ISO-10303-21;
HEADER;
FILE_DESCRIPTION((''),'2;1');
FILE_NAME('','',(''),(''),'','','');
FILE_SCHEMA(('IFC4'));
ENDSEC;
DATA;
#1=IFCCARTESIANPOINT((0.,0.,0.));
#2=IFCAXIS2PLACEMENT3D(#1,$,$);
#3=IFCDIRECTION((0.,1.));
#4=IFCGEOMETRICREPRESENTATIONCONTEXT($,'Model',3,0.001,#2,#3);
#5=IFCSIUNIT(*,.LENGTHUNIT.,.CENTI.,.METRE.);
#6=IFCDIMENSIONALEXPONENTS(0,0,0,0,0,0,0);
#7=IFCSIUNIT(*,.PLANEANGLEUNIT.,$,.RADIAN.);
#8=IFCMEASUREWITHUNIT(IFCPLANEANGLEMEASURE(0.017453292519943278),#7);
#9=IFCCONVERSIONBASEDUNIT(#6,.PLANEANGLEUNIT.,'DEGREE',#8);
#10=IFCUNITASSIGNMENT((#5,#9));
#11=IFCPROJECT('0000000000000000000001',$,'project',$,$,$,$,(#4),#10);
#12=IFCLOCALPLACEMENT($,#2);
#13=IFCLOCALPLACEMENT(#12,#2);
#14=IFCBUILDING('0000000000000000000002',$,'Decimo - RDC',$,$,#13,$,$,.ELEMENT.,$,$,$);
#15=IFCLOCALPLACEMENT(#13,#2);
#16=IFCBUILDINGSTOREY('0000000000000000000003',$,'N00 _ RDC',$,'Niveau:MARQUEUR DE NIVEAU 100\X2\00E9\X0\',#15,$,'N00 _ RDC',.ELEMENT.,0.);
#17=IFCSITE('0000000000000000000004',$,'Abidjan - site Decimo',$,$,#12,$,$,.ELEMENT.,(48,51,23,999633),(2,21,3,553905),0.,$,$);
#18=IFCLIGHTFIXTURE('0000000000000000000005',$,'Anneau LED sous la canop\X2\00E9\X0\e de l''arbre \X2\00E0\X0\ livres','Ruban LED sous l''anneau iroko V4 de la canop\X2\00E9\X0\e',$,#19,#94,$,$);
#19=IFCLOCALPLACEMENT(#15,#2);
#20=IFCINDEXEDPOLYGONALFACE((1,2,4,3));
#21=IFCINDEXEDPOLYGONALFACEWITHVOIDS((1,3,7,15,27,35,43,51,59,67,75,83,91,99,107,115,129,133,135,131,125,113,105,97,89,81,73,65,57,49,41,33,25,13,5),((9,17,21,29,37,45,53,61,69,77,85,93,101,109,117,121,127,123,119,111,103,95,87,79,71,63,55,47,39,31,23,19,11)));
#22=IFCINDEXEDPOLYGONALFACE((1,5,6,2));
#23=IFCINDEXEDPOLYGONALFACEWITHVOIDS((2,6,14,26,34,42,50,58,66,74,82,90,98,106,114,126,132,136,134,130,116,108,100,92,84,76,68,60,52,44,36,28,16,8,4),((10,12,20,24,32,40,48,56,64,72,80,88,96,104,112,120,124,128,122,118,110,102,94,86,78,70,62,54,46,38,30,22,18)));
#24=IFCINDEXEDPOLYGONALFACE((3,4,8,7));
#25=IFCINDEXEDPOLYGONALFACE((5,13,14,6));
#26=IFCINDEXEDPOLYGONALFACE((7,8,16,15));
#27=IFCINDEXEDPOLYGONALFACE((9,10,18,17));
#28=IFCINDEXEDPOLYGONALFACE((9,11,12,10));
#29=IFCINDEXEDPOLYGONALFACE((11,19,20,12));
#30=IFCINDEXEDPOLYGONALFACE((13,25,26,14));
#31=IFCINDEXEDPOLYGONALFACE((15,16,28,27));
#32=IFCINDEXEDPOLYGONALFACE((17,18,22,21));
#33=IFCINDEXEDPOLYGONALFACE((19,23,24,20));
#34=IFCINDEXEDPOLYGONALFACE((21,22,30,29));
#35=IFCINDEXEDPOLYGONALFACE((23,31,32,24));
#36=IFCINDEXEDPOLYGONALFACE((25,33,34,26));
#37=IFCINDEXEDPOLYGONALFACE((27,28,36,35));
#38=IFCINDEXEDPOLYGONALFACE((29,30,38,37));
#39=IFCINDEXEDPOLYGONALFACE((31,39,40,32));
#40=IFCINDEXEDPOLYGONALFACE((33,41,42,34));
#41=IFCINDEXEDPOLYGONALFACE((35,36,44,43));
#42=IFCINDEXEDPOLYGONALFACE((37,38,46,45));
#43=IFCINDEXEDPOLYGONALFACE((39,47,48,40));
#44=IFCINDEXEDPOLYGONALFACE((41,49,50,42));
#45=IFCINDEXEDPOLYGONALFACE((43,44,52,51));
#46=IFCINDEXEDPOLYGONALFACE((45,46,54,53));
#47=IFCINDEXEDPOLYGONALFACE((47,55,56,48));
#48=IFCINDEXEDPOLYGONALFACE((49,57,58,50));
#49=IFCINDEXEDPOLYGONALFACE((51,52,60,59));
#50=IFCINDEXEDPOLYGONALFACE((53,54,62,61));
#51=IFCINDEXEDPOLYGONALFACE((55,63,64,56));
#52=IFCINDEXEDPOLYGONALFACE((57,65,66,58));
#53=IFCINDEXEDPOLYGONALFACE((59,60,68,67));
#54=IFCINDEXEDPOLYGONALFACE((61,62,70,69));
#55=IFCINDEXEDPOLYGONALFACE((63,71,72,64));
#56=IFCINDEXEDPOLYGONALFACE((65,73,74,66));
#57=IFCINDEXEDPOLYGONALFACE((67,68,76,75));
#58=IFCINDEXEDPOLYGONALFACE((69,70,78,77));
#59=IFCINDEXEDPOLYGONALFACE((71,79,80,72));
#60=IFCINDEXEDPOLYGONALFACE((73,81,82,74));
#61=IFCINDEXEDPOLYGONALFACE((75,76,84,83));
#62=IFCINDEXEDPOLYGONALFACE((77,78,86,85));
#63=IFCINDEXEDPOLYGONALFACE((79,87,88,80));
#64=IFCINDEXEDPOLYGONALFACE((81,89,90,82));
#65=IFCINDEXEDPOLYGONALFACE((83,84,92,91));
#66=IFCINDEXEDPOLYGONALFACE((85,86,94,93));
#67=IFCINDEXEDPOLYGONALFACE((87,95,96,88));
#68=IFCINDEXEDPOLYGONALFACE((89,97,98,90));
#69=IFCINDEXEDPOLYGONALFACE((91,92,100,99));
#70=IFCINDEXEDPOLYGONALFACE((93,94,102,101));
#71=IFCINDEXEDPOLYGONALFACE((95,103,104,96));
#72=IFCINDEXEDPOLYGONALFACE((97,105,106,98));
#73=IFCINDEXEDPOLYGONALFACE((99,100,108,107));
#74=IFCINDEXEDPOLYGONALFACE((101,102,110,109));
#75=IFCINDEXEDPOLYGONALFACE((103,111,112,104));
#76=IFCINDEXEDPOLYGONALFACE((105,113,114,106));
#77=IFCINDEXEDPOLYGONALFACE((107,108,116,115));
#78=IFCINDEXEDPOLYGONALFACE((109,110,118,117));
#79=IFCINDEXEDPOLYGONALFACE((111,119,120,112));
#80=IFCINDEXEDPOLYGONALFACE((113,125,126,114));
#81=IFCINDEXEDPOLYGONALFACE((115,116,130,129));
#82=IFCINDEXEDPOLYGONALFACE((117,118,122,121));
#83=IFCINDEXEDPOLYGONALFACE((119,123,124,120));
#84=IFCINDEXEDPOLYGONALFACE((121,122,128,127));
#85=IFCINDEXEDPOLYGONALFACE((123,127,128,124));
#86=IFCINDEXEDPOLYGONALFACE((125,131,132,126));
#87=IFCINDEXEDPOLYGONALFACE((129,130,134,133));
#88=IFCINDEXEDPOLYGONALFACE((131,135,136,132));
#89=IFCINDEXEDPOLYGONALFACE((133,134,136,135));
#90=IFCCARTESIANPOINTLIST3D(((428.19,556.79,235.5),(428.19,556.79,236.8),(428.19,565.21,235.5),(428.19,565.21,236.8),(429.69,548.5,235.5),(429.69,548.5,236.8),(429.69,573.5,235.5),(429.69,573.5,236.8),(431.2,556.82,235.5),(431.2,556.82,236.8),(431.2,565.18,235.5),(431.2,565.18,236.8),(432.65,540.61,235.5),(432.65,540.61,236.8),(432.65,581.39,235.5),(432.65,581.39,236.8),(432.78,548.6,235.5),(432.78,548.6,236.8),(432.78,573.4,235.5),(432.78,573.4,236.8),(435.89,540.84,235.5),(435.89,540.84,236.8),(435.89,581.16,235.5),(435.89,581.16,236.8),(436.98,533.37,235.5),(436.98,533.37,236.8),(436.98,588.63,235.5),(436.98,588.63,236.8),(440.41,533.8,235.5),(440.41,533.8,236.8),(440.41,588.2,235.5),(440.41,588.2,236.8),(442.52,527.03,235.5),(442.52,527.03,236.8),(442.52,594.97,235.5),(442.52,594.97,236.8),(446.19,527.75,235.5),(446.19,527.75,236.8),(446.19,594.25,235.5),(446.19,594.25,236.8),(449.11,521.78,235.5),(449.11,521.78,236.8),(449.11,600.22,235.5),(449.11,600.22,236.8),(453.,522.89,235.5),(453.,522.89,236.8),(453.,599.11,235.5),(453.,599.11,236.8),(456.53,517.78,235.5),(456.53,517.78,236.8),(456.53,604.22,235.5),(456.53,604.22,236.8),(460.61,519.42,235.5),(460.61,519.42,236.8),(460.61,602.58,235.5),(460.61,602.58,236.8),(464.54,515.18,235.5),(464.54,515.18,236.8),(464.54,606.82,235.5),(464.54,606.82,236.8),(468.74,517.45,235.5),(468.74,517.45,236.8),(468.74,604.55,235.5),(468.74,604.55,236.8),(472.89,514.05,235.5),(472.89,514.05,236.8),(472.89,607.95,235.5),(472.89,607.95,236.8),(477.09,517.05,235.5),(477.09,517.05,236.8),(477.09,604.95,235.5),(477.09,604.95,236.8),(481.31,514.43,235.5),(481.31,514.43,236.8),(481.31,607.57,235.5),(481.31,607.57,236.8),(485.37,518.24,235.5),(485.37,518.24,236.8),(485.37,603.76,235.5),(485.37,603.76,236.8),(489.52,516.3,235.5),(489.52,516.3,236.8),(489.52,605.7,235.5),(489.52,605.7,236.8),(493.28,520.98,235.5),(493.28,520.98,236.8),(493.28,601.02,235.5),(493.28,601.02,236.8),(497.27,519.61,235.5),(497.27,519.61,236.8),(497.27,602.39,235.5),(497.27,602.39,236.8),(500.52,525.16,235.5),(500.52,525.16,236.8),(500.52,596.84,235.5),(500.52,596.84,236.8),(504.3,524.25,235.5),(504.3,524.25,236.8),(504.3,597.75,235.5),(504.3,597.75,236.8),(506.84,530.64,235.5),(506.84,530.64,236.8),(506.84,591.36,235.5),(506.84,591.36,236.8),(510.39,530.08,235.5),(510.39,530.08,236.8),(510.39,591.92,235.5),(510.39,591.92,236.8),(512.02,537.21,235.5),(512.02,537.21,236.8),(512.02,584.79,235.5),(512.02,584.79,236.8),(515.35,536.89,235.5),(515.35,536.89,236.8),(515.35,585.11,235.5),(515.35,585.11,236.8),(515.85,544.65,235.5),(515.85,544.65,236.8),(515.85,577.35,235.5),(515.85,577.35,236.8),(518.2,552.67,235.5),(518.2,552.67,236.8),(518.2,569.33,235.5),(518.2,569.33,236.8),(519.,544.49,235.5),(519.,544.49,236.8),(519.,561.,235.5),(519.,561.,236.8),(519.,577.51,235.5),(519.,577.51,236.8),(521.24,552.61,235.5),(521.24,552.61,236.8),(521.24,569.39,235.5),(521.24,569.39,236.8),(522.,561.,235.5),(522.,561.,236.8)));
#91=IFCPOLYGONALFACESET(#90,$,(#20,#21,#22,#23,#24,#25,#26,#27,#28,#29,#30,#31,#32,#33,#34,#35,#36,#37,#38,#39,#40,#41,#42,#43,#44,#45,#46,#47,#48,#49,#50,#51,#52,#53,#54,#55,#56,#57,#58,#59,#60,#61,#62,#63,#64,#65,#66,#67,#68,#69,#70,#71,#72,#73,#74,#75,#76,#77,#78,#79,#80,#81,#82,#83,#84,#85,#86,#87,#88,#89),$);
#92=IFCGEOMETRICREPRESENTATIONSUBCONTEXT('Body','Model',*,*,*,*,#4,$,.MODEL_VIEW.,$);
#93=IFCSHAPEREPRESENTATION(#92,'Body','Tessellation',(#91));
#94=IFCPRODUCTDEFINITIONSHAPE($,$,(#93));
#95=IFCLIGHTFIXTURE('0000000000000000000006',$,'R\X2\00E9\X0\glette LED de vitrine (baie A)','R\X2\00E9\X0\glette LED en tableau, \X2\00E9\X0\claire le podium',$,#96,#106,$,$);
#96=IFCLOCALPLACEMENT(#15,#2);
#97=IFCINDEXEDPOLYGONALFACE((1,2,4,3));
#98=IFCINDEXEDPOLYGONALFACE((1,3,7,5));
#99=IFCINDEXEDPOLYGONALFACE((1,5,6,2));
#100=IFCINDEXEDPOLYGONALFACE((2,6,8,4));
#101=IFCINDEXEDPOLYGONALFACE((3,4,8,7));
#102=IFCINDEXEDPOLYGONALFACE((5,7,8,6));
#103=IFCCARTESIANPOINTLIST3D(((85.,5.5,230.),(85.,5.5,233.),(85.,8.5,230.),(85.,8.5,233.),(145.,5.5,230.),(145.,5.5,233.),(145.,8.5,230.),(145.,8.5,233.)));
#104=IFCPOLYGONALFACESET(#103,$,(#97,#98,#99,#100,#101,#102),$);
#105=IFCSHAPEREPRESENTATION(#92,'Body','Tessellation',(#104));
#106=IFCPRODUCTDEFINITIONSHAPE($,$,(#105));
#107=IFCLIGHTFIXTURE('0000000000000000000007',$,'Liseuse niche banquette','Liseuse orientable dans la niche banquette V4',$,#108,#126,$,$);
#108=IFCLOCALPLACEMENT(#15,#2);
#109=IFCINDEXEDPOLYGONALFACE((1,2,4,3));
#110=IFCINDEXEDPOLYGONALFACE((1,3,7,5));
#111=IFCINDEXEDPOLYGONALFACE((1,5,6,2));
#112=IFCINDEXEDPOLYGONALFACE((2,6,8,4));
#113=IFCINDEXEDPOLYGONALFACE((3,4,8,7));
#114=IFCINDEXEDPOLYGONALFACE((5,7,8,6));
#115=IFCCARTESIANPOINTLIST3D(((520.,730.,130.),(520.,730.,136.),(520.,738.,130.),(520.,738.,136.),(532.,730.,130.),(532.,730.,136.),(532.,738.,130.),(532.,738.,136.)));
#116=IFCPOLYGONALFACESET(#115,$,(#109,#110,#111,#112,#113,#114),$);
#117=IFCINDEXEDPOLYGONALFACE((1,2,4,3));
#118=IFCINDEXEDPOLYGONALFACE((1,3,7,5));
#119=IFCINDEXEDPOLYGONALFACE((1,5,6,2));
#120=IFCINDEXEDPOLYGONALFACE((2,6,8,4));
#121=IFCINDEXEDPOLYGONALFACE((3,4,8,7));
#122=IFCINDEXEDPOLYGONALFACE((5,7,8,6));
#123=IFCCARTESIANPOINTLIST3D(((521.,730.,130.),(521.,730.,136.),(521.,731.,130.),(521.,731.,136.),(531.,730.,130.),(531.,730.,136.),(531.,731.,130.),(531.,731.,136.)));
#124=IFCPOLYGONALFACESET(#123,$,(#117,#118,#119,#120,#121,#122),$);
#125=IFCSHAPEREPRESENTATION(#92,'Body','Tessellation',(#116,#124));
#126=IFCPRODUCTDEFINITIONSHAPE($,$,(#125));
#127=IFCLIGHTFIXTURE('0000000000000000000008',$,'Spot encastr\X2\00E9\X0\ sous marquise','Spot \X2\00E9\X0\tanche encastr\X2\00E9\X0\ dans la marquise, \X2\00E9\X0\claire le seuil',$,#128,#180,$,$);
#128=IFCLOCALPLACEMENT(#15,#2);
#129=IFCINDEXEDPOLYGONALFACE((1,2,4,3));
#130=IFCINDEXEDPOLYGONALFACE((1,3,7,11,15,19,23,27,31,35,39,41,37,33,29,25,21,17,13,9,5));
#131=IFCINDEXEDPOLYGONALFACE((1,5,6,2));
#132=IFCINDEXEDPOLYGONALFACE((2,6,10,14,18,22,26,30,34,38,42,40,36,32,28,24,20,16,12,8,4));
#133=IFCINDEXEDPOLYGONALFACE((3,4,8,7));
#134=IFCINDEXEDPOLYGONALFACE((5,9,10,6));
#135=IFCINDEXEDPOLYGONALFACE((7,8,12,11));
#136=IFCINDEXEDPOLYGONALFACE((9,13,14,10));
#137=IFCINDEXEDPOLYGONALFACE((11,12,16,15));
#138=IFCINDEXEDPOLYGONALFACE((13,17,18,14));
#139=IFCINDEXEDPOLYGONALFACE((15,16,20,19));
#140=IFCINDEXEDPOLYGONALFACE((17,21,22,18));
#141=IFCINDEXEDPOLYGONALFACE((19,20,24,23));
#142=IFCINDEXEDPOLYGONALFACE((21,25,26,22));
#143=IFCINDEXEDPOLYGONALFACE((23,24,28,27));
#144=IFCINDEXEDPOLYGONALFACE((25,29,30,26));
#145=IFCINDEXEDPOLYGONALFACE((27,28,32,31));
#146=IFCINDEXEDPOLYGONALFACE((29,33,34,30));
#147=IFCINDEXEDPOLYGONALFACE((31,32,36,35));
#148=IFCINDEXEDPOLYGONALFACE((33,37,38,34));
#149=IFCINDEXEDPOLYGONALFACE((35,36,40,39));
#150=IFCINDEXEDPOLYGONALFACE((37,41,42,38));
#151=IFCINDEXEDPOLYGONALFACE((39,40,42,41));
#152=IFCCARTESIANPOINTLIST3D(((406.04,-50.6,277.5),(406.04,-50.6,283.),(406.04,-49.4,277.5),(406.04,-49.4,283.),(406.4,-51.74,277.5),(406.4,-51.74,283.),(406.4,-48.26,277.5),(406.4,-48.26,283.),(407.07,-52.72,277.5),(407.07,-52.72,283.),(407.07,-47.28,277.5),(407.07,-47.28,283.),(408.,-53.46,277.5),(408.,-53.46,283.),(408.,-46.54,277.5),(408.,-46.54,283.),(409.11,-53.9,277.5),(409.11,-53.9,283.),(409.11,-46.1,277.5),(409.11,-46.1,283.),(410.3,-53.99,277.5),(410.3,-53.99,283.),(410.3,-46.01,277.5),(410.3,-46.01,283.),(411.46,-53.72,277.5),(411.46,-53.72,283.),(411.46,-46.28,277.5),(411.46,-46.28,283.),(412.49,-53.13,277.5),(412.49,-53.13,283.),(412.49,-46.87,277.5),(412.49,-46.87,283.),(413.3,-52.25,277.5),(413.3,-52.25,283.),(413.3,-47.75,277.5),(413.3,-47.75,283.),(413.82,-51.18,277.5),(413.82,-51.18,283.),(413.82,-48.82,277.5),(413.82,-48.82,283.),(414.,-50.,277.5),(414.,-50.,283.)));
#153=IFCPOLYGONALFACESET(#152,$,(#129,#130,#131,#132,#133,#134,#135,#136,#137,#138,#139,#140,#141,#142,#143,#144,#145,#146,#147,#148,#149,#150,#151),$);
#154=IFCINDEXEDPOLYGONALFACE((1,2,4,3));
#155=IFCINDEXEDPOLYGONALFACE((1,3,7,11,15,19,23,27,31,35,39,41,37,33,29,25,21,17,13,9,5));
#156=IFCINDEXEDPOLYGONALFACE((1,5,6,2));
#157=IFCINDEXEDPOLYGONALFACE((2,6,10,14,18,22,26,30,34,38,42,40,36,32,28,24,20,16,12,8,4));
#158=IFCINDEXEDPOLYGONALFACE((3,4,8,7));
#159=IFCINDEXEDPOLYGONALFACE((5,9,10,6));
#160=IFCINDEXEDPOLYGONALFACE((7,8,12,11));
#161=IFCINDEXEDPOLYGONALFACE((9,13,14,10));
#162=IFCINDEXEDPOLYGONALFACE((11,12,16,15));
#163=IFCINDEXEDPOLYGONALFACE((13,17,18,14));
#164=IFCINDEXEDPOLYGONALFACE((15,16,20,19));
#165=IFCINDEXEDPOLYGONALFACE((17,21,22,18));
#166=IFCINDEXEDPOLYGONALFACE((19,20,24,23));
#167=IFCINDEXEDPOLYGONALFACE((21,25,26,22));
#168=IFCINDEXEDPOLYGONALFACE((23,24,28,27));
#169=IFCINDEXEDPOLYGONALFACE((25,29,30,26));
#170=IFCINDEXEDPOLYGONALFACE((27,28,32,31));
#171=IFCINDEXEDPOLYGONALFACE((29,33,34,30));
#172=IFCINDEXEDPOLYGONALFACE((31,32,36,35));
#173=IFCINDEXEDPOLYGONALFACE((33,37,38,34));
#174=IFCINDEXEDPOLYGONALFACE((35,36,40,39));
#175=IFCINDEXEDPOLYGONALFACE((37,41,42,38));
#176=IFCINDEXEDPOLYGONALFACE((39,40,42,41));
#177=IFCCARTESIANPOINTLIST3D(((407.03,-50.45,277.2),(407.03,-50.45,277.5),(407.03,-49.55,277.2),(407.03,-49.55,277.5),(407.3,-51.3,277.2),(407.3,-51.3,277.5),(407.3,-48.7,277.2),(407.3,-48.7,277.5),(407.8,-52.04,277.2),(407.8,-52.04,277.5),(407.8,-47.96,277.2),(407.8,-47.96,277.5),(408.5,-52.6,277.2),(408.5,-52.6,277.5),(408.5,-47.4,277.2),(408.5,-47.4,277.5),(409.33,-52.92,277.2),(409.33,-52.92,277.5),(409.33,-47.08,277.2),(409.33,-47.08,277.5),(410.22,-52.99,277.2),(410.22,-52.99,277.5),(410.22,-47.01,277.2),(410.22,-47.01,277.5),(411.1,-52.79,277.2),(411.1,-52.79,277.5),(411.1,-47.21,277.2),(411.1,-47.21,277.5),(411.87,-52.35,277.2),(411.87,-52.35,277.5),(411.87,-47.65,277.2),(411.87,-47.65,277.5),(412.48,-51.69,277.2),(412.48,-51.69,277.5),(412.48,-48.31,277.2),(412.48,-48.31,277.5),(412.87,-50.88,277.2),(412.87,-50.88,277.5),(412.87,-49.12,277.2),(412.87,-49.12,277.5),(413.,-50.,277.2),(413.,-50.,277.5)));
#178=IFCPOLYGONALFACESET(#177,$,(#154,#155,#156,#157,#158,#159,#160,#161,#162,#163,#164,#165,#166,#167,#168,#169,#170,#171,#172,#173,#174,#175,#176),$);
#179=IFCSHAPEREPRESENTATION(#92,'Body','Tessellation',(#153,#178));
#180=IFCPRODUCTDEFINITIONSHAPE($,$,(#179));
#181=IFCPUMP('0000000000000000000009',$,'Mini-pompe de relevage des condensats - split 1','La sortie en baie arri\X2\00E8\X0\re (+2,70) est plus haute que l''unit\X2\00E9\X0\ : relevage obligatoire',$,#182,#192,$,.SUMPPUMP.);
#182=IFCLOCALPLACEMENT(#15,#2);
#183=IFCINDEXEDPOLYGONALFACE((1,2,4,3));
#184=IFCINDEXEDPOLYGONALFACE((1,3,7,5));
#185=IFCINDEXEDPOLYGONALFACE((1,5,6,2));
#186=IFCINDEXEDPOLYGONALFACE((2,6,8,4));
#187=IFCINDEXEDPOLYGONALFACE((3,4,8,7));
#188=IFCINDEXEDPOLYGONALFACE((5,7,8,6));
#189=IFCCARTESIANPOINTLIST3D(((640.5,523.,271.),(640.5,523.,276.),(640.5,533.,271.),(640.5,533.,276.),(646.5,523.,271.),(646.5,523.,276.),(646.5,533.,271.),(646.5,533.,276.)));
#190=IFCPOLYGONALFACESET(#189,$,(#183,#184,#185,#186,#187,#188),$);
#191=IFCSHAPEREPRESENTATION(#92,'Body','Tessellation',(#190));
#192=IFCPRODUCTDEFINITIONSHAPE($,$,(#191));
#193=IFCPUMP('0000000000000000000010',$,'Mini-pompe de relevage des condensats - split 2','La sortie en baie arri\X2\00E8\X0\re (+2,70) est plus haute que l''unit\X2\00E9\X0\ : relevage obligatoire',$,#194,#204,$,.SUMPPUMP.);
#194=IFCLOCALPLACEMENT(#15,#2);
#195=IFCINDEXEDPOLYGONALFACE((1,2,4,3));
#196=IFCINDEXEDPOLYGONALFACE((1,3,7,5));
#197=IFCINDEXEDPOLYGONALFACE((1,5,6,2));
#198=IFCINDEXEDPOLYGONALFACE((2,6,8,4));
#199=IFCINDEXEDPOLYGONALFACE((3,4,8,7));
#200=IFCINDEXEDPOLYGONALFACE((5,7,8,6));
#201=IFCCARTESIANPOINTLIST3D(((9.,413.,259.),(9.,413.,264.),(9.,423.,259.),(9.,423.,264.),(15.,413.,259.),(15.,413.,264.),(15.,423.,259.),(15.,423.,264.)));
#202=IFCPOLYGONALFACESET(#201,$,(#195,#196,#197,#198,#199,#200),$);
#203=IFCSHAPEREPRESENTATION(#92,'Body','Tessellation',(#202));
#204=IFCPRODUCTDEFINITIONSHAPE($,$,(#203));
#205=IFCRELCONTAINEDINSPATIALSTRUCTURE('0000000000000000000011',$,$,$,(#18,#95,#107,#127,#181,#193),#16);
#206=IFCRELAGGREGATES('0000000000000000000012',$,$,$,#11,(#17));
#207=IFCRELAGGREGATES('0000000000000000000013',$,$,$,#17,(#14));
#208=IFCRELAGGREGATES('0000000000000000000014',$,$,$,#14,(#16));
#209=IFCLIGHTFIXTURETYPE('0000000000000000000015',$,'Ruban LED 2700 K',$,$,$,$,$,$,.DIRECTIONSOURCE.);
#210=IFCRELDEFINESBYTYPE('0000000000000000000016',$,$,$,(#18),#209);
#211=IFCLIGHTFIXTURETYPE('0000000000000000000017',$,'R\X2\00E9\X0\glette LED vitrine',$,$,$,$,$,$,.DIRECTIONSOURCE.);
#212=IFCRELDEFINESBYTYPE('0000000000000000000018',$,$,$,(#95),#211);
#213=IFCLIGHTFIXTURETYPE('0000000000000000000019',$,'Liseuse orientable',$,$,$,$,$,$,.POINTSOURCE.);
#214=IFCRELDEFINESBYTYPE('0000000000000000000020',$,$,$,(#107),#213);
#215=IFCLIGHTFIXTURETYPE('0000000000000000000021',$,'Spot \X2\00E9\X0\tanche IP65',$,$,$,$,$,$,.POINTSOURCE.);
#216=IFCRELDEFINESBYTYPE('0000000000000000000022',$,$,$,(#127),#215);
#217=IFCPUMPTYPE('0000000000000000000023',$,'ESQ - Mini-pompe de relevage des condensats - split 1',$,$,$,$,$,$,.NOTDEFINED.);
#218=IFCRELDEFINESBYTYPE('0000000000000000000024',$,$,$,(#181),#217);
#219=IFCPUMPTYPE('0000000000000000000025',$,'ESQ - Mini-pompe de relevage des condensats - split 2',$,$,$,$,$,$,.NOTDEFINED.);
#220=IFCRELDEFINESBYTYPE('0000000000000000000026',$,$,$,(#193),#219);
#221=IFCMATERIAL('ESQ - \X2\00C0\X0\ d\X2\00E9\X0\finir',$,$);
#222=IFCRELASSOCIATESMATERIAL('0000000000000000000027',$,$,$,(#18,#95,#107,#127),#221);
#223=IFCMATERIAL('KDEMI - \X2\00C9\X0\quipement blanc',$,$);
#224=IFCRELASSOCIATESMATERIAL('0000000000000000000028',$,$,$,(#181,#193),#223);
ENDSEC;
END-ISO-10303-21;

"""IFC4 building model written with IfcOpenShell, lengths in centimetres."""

from ifc_helpers import new_model, entity, si_unit, converted_unit, direction, frame, frame_2d, origin, origin_with_axes, place, context, subcontext, project, spatial, rectangle, circle, hollow_circle, extrude, material, type_object, element, save


model = new_model("IFC4")

# Units and contexts
model_context = context("Model", 3, precision=0.001, world=origin(), true_north=direction((0.0, 1.0)))
body_context = subcontext(model_context, "Body", "Model", "MODEL_VIEW")
ifc_project = project(units=[si_unit("LENGTHUNIT", "METRE", prefix="CENTI"), converted_unit("PLANEANGLEUNIT", "DEGREE", entity("IfcPlaneAngleMeasure", 0.017453292519943278), si_unit("PLANEANGLEUNIT", "RADIAN"), dimensions=[0, 0, 0, 0, 0, 0, 0])], contexts=[model_context])

# Site, building, storey
site_placement = place(None, origin())
site = spatial("IfcSite", under=ifc_project, at=site_placement, Name="Abidjan - site Decimo", CompositionType="ELEMENT", RefLatitude=(48, 51, 23, 999633), RefLongitude=(2, 21, 3, 553905), RefElevation=0.0)
building_placement = place(site_placement, origin())
building = spatial("IfcBuilding", under=site, at=building_placement, Name="Decimo - RDC", CompositionType="ELEMENT")
storey_placement = place(building_placement, origin())
storey = spatial("IfcBuildingStorey", under=building, at=storey_placement, Name="N00 _ RDC", ObjectType="Niveau:MARQUEUR DE NIVEAU 100é", LongName="N00 _ RDC", CompositionType="ELEMENT", Elevation=0.0)

# Light fixtures
ifc_material_1 = material(Name="ESQ - À définir")
light_fixture_type_1 = type_object("IfcLightFixtureType", Name="Ruban LED 2700 K", PredefinedType="DIRECTIONSOURCE")
light_fixture_1_placement = place(storey_placement, origin_with_axes())
element("IfcLightFixture", 1, at=light_fixture_1_placement, inside=storey, type_object=light_fixture_type_1, material=ifc_material_1, Name="Anneau LED sous la canopée de l'arbre à livres", Description="Ruban LED sous l'anneau iroko V4 de la canopée", context=body_context, shape_type="SweptSolid", body=[
    extrude(hollow_circle(Radius=47.0, WallThickness=3.0, at=frame_2d((475.0, 561.0))), frame((0.0, 0.0, 235.5)), (0.0, 0.0, 1.0), 1.3),
])
light_fixture_type_2 = type_object("IfcLightFixtureType", Name="Réglette LED vitrine", PredefinedType="DIRECTIONSOURCE")
light_fixture_2_placement = place(storey_placement, origin_with_axes())
element("IfcLightFixture", 2, at=light_fixture_2_placement, inside=storey, type_object=light_fixture_type_2, material=ifc_material_1, Name="Réglette LED de vitrine (baie A)", Description="Réglette LED en tableau, éclaire le podium", context=body_context, shape_type="SweptSolid", body=[
    extrude(rectangle(XDim=60.0, YDim=3.0, at=frame_2d((115.0, 7.0))), frame((0.0, 0.0, 230.0)), (0.0, 0.0, 1.0), 3.0),
])
light_fixture_type_3 = type_object("IfcLightFixtureType", Name="Liseuse orientable", PredefinedType="POINTSOURCE")
light_fixture_3_placement = place(storey_placement, origin_with_axes())
element("IfcLightFixture", 3, at=light_fixture_3_placement, inside=storey, type_object=light_fixture_type_3, material=ifc_material_1, Name="Liseuse niche banquette", Description="Liseuse orientable dans la niche banquette V4", context=body_context, shape_type="SweptSolid", body=[
    extrude(rectangle(XDim=12.0, YDim=8.0, at=frame_2d((526.0, 734.0))), frame((0.0, 0.0, 130.0)), (0.0, 0.0, 1.0), 6.0),
    extrude(rectangle(XDim=10.0, YDim=1.0, at=frame_2d((526.0, 730.5))), frame((0.0, 0.0, 130.0)), (0.0, 0.0, 1.0), 6.0),
])
light_fixture_type_4 = type_object("IfcLightFixtureType", Name="Spot étanche IP65", PredefinedType="POINTSOURCE")
light_fixture_4_placement = place(storey_placement, origin_with_axes())
element("IfcLightFixture", 4, at=light_fixture_4_placement, inside=storey, type_object=light_fixture_type_4, material=ifc_material_1, Name="Spot encastré sous marquise", Description="Spot étanche encastré dans la marquise, éclaire le seuil", context=body_context, shape_type="SweptSolid", body=[
    extrude(circle(Radius=4.0, at=frame_2d((410.0, -50.0))), frame((0.0, 0.0, 277.5)), (0.0, 0.0, 1.0), 5.5),
    extrude(circle(Radius=3.0, at=frame_2d((410.0, -50.0))), frame((0.0, 0.0, 277.2)), (0.0, 0.0, 1.0), 0.3),
])

# Pumps
ifc_material_2 = material(Name="KDEMI - Équipement blanc")
pump_type_1 = type_object("IfcPumpType", Name="ESQ - Mini-pompe de relevage des condensats - split 1", PredefinedType="NOTDEFINED")
pump_1_placement = place(storey_placement, origin_with_axes())
element("IfcPump", 5, at=pump_1_placement, inside=storey, type_object=pump_type_1, material=ifc_material_2, Name="Mini-pompe de relevage des condensats - split 1", Description="La sortie en baie arrière (+2,70) est plus haute que l'unité : relevage obligatoire", PredefinedType="SUMPPUMP", context=body_context, shape_type="SweptSolid", body=[
    extrude(rectangle(XDim=6.0, YDim=10.0, at=frame_2d((643.5, 528.0))), frame((0.0, 0.0, 271.0)), (0.0, 0.0, 1.0), 5.0),
])
pump_type_2 = type_object("IfcPumpType", Name="ESQ - Mini-pompe de relevage des condensats - split 2", PredefinedType="NOTDEFINED")
pump_2_placement = place(storey_placement, origin_with_axes())
element("IfcPump", 6, at=pump_2_placement, inside=storey, type_object=pump_type_2, material=ifc_material_2, Name="Mini-pompe de relevage des condensats - split 2", Description="La sortie en baie arrière (+2,70) est plus haute que l'unité : relevage obligatoire", PredefinedType="SUMPPUMP", context=body_context, shape_type="SweptSolid", body=[
    extrude(rectangle(XDim=6.0, YDim=10.0, at=frame_2d((12.0, 418.0))), frame((0.0, 0.0, 259.0)), (0.0, 0.0, 1.0), 5.0),
])

save(model, "model.ifc")
